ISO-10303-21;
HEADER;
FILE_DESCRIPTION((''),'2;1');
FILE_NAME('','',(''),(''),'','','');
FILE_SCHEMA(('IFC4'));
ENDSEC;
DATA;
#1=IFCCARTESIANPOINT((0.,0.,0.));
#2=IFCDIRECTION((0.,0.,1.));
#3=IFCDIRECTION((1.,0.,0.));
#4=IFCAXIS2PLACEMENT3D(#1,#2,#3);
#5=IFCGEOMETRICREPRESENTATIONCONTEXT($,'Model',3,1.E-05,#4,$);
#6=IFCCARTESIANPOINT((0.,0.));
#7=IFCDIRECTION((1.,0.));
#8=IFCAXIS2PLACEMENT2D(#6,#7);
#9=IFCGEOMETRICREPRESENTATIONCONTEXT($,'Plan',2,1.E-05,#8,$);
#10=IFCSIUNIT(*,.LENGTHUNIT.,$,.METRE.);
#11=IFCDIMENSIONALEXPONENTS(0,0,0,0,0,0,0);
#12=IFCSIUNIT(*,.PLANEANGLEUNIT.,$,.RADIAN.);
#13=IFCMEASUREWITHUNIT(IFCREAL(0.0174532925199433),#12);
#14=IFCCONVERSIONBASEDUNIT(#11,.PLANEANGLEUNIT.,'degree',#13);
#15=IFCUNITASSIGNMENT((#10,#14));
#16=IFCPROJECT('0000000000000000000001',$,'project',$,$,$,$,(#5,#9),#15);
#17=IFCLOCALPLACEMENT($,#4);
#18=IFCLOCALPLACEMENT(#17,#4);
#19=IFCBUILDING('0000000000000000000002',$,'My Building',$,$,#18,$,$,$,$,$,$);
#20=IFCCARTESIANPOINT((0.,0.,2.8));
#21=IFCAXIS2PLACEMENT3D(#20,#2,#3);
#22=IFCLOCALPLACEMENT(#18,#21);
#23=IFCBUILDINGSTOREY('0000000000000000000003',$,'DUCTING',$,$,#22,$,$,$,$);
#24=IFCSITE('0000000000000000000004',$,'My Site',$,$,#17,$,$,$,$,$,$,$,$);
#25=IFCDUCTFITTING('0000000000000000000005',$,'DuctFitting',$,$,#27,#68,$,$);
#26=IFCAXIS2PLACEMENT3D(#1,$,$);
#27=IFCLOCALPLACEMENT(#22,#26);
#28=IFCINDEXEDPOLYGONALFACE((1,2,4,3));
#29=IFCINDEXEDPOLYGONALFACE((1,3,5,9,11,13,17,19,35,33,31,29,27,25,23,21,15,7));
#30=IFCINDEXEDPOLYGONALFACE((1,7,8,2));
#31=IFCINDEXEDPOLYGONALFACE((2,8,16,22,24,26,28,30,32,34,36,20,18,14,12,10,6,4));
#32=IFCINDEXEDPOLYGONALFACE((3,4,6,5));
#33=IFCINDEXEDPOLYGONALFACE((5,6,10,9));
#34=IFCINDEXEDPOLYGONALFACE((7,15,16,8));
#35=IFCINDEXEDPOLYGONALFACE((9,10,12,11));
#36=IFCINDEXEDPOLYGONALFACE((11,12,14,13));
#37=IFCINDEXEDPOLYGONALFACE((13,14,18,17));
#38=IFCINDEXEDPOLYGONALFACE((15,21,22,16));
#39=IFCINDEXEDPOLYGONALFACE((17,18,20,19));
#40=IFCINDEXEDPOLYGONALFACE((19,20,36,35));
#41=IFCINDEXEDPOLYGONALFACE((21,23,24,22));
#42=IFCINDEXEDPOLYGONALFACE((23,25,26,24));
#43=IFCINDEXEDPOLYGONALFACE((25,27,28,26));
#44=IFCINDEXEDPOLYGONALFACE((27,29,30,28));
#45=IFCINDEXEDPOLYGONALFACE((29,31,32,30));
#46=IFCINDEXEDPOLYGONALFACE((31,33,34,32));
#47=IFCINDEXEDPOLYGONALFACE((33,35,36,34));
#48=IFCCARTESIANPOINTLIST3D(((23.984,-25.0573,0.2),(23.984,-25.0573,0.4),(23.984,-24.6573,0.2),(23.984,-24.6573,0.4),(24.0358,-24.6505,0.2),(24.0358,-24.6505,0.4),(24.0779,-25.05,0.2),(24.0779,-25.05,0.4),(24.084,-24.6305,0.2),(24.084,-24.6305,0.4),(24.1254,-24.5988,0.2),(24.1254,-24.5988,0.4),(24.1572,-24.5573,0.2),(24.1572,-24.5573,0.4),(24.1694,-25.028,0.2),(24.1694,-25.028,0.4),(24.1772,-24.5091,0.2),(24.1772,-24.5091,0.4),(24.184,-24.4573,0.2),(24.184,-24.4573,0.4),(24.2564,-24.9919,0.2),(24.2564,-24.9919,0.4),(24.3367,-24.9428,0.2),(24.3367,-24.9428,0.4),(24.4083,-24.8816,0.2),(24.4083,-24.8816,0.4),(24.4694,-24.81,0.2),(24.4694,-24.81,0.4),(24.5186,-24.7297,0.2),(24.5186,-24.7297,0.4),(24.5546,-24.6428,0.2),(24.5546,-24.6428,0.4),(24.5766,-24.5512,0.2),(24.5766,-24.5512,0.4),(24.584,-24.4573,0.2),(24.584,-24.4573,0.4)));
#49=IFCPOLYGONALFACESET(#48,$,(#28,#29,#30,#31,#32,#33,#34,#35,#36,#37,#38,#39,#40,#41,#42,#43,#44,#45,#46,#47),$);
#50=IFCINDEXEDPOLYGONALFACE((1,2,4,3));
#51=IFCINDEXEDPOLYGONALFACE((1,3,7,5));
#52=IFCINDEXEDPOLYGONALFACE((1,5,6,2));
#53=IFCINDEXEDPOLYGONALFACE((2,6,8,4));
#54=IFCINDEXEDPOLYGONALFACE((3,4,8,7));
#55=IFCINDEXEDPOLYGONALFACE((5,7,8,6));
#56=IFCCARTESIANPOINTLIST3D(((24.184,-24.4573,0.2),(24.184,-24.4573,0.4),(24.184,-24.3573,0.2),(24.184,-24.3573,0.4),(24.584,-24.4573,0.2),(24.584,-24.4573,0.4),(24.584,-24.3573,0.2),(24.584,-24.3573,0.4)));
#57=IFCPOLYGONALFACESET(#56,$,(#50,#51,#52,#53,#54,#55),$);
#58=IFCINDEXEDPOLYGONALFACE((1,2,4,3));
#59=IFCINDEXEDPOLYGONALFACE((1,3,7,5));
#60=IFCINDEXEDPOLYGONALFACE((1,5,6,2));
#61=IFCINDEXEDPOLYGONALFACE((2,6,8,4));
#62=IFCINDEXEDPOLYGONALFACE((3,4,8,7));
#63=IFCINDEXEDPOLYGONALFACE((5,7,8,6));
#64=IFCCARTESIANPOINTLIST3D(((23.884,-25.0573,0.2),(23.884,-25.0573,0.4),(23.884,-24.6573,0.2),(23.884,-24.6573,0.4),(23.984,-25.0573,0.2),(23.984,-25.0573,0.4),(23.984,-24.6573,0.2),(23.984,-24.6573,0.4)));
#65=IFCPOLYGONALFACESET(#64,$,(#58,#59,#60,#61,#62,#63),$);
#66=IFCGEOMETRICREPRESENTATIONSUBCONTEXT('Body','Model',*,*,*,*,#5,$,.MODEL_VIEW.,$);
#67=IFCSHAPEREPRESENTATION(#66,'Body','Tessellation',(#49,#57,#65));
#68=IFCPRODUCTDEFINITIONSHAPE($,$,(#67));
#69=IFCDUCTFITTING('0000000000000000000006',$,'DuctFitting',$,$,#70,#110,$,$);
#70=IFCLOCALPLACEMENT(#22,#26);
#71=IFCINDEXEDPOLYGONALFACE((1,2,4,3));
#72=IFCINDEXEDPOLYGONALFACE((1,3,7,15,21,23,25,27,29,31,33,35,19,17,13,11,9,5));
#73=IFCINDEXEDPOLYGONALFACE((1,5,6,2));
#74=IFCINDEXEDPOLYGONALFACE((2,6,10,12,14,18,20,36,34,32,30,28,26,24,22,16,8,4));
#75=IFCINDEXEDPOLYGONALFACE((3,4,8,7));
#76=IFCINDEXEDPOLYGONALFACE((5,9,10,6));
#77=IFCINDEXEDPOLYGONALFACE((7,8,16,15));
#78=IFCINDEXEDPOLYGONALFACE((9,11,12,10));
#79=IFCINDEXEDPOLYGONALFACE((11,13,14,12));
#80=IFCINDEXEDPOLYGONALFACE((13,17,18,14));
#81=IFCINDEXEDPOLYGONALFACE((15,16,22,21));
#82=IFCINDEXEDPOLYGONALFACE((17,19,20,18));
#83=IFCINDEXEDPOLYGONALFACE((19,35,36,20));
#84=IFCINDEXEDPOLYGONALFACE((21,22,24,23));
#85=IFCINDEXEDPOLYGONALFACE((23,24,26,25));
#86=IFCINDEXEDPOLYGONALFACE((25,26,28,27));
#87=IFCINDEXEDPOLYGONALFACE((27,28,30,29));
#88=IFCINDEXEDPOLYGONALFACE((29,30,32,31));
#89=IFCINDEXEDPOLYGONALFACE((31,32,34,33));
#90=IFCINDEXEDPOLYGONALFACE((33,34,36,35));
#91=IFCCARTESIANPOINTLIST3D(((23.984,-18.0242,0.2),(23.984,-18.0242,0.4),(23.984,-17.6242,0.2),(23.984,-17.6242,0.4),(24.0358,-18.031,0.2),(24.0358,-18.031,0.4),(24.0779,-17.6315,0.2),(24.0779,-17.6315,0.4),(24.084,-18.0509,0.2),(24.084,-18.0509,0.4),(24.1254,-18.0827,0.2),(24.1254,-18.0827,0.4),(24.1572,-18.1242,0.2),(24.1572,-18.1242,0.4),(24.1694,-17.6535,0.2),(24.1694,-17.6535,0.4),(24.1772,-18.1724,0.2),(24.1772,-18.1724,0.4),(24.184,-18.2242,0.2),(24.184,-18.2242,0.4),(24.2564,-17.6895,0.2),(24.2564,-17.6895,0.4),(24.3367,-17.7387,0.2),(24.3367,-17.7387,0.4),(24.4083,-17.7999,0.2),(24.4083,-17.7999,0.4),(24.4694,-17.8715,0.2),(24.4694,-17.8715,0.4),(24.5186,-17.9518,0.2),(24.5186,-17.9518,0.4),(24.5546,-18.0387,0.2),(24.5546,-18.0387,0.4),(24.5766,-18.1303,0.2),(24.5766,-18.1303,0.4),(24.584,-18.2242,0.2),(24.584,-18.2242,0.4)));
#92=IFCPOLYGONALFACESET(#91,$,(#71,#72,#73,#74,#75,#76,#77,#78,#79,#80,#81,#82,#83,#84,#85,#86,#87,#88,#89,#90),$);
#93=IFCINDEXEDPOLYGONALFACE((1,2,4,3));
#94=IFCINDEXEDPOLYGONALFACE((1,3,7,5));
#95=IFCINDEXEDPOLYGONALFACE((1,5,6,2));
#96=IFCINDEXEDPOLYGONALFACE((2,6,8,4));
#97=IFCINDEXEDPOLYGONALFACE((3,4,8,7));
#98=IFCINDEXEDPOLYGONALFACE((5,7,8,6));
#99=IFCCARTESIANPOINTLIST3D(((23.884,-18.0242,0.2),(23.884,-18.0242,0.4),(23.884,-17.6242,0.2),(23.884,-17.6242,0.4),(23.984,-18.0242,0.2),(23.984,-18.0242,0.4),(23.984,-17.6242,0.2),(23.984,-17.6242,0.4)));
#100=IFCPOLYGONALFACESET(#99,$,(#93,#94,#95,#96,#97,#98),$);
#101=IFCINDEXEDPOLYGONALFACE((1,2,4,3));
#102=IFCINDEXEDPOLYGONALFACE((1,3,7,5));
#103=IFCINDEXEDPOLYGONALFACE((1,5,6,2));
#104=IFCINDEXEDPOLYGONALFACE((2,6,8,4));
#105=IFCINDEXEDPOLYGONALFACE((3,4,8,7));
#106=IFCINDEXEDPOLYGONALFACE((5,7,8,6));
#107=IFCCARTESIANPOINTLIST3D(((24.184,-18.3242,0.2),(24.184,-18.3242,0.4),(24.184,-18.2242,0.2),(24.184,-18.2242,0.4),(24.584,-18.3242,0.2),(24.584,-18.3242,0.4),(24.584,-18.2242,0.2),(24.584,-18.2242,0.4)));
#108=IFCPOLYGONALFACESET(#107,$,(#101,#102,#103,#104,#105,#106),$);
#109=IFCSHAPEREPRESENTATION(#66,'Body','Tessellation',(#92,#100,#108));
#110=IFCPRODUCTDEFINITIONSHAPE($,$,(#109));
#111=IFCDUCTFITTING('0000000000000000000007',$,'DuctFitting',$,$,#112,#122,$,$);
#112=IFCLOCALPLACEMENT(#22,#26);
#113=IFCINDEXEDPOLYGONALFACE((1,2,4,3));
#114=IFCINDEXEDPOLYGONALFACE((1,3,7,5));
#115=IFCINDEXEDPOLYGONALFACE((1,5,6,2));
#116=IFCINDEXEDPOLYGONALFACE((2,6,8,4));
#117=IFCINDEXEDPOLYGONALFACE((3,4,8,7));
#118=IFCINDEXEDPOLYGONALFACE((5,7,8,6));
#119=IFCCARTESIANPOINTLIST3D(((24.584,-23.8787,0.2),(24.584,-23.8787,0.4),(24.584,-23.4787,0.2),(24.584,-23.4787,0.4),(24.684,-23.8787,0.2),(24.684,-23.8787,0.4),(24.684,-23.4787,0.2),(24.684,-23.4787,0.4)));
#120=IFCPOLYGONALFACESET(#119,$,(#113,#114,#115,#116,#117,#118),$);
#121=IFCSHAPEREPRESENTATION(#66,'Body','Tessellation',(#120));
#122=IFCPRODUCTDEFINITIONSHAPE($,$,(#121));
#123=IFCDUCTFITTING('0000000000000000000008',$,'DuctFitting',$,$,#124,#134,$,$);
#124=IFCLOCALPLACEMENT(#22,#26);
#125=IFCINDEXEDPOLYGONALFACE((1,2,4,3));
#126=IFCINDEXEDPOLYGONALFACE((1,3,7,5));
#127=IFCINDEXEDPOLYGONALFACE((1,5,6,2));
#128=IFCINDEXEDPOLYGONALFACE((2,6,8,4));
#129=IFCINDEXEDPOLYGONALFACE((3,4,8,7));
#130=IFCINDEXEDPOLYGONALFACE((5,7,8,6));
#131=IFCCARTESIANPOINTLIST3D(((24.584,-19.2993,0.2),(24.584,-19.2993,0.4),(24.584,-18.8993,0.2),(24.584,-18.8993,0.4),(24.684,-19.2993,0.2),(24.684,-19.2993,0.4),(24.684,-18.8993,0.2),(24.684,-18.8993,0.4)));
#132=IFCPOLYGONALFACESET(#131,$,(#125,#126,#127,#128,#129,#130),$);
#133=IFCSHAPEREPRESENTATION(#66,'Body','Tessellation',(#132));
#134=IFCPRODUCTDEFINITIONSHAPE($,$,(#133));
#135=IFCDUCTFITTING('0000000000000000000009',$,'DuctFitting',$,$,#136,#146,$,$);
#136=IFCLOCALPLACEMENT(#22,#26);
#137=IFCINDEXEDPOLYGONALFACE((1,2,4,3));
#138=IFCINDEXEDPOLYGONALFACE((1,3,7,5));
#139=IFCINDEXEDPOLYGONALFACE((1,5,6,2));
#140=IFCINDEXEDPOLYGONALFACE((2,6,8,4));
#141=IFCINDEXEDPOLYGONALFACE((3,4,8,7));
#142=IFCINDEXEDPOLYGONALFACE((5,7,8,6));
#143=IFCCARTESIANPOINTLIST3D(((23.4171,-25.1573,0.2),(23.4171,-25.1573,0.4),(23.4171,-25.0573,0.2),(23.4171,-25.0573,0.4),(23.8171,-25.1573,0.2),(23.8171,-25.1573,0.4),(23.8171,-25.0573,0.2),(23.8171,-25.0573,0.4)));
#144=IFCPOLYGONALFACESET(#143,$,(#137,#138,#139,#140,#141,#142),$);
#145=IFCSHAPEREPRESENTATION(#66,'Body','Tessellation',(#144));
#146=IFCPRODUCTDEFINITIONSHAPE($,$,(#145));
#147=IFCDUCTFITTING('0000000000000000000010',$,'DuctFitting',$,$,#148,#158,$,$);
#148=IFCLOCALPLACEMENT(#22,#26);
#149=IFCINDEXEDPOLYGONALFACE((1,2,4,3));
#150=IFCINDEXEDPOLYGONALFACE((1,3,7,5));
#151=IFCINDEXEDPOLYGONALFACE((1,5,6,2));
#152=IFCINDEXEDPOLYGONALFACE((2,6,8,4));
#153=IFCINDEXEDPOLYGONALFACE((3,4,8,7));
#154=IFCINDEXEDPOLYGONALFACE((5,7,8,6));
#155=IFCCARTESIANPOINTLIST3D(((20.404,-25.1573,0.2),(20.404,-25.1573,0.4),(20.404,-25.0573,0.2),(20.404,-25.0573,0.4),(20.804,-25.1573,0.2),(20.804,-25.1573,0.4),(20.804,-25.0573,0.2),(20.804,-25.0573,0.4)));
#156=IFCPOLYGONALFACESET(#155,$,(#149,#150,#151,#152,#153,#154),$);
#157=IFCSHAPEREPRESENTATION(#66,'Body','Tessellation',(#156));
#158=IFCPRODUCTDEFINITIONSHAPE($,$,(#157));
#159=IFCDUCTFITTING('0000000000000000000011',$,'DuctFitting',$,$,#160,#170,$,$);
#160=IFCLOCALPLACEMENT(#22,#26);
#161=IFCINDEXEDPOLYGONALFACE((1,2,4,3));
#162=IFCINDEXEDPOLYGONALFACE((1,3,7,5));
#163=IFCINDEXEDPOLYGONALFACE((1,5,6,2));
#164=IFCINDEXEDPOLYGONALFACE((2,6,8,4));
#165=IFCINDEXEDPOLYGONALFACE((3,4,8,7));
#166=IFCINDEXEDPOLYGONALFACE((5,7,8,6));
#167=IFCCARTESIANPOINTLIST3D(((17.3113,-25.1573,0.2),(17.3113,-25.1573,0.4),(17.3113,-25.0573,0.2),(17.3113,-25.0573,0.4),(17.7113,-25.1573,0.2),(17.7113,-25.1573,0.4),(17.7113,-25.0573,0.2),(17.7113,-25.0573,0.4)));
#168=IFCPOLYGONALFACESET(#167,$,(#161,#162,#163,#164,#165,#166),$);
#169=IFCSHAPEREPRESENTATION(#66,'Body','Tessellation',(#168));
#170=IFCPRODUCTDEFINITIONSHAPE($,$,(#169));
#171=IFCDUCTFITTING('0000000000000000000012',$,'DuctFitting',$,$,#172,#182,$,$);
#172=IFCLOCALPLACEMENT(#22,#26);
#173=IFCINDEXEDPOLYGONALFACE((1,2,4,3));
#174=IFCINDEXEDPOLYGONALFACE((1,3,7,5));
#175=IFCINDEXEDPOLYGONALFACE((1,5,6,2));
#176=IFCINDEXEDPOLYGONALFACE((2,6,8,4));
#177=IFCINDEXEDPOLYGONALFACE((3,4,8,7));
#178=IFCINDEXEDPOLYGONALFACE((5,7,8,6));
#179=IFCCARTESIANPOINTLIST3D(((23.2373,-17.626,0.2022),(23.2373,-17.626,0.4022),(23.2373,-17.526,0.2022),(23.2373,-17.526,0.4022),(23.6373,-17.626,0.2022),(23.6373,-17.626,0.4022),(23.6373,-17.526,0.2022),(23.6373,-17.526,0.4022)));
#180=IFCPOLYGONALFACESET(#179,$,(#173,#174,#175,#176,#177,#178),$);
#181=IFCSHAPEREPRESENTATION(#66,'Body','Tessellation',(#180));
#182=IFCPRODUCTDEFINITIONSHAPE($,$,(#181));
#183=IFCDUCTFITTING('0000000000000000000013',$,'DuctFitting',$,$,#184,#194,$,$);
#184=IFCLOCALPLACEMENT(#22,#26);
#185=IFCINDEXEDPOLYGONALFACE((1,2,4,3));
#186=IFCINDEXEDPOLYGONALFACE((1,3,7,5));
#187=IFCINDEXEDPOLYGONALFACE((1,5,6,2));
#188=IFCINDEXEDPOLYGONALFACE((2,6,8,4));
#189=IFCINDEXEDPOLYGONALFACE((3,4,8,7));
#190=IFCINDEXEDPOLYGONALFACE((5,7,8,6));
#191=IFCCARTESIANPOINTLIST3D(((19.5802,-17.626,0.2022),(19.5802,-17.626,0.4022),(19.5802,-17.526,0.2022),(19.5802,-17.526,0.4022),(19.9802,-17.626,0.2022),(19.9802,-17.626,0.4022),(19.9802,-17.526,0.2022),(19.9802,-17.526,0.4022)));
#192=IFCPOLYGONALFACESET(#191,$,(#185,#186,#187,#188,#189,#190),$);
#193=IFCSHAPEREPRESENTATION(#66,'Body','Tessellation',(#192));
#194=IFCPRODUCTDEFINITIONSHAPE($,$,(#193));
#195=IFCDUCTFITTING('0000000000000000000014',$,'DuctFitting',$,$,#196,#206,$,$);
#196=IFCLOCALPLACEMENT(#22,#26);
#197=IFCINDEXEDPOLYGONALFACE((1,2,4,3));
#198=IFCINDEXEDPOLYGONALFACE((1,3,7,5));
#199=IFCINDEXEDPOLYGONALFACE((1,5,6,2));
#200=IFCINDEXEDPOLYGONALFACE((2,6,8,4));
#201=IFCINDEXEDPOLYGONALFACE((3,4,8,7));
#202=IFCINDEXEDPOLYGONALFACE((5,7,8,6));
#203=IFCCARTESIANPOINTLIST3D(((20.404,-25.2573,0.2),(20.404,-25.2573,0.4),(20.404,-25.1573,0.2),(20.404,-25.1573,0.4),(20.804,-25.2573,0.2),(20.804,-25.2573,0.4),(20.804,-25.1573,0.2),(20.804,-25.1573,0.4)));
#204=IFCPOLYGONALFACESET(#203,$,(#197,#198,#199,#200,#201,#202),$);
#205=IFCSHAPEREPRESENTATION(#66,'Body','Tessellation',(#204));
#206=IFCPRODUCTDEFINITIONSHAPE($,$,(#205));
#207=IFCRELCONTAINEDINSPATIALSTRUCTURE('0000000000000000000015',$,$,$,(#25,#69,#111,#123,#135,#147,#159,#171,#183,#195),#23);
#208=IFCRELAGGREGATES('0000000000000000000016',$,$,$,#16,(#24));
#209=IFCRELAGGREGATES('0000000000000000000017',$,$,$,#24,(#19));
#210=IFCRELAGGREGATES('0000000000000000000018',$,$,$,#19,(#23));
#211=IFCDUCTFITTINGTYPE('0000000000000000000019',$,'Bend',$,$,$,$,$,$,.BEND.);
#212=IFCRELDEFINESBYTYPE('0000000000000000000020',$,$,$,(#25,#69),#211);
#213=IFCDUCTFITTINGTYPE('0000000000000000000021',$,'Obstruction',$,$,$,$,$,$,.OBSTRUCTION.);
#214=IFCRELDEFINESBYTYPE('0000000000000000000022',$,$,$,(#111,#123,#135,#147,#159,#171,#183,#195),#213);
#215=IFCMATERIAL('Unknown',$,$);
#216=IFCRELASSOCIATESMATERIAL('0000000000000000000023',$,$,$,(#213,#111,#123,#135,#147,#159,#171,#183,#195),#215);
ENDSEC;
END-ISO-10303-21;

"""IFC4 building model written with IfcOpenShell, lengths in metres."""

from ifc_helpers import new_model, entity, si_unit, converted_unit, frame, origin_with_axes, origin_2d_with_axis, place, context, subcontext, project, spatial, line, arc, indexed_curve, rectangle, outline, extrude, source, transform, mapped, material, material_profile, profile_set, profile_usage, type_object, type_shapes, element, save


model = new_model("IFC4")

# Units and contexts
model_context = context("Model", 3, precision=1e-05, world=origin_with_axes())
plan_context = context("Plan", 2, precision=1e-05, world=origin_2d_with_axis())
body_context = subcontext(model_context, "Body", "Model", "MODEL_VIEW")
ifc_project = project(units=[si_unit("LENGTHUNIT", "METRE"), converted_unit("PLANEANGLEUNIT", "degree", entity("IfcReal", 0.0174532925199433), si_unit("PLANEANGLEUNIT", "RADIAN"), dimensions=[0, 0, 0, 0, 0, 0, 0])], contexts=[model_context, plan_context])

# Site, building, storey
site_placement = place(None, origin_with_axes())
site = spatial("IfcSite", under=ifc_project, at=site_placement, Name="My Site")
building_placement = place(site_placement, origin_with_axes())
building = spatial("IfcBuilding", under=site, at=building_placement, Name="My Building")
storey_placement = place(building_placement, frame((0.0, 0.0, 2.8), z_axis=(0.0, 0.0, 1.0), x_axis=(1.0, 0.0, 0.0)))
storey = spatial("IfcBuildingStorey", under=building, at=storey_placement, Name="DUCTING")

# Shared definitions
ifc_material = material(Name="Unknown")

# Duct fittings
duct_fitting_type_1 = type_object("IfcDuctFittingType", Name="Bend", PredefinedType="BEND")
shared_shape = source(origin_with_axes(), body_context, "Body", "SweptSolid", [
    extrude(outline(indexed_curve([(-0.2, 0.0), (-0.2586, 0.1414), (-0.4, 0.2), (-0.4, 0.6), (0.0243, 0.4243), (0.2, 0.0)], segments=[arc(1, 2, 3), line(3, 4), arc(4, 5, 6), line(6, 1)])), frame((0.0, -0.1, 0.1), z_axis=(0.0, -1.0, 0.0), x_axis=(1.0, 0.0, 0.0)), (0.0, 0.0, -1.0), 0.2),
    extrude(rectangle(XDim=0.4, YDim=0.2), origin_with_axes(), (0.0, 0.0, 1.0), 0.1),
    extrude(rectangle(XDim=0.4, YDim=0.2), frame((-0.4, 0.0, 0.5), z_axis=(-1.0, 0.0, 0.0), x_axis=(0.0, 0.0, -1.0)), (0.0, 0.0, 1.0), 0.1),
])
type_shapes(duct_fitting_type_1, [shared_shape])
for number, where, z_axis, x_axis, name in (
    (1, (24.384, -24.3573, 0.3), (0.0, -1.0, 0.000006), (1.0, 0.0, 0.0), "DuctFitting"),
    (2, (23.884, -17.8242, 0.3), (1.0, 0.0, 0.0), (0.0, 1.0, 0.0), "DuctFitting"),
):
    element("IfcDuctFitting", number, at=place(storey_placement, frame(where, z_axis=z_axis, x_axis=x_axis)), inside=storey, type_object=duct_fitting_type_1, Name=name, context=body_context, shape_type="MappedRepresentation", body=[
        mapped(shared_shape, transform((0.0, 0.0, 0.0), x_axis=(1.0, 0.0, 0.0), y_axis=(0.0, 1.0, 0.0), z_axis=(0.0, 0.0, 1.0), scale=1.0)),
    ])
ifc_material_profile_1 = material_profile(ifc_material, rectangle(XDim=0.4, YDim=0.2))
ifc_profile_set_1 = profile_set([ifc_material_profile_1])
ifc_profile_usage_1 = profile_usage(ifc_profile_set_1, cardinal=5)
duct_fitting_type_2 = type_object("IfcDuctFittingType", Name="Obstruction", PredefinedType="OBSTRUCTION", material=ifc_profile_set_1)
duct_fitting_1_placement = place(storey_placement, frame((24.584, -23.6787, 0.3), z_axis=(1.0, 0.0, 0.0), x_axis=(0.0, 1.0, 0.0)))
element("IfcDuctFitting", 3, at=duct_fitting_1_placement, inside=storey, type_object=duct_fitting_type_2, material=ifc_profile_usage_1, Name="DuctFitting", context=body_context, shape_type="SweptSolid", body=[
    extrude(rectangle(XDim=0.4, YDim=0.2), origin_with_axes(), (0.0, 0.0, 1.0), 0.1),
])
ifc_profile_usage_2 = profile_usage(ifc_profile_set_1, cardinal=5)
duct_fitting_2_placement = place(storey_placement, frame((24.584, -19.0993, 0.3), z_axis=(1.0, 0.0, 0.0), x_axis=(0.0, 1.0, 0.0)))
element("IfcDuctFitting", 4, at=duct_fitting_2_placement, inside=storey, type_object=duct_fitting_type_2, material=ifc_profile_usage_2, Name="DuctFitting", context=body_context, shape_type="SweptSolid", body=[
    extrude(rectangle(XDim=0.4, YDim=0.2), origin_with_axes(), (0.0, 0.0, 1.0), 0.1),
])
ifc_profile_usage_3 = profile_usage(ifc_profile_set_1, cardinal=5)
duct_fitting_3_placement = place(storey_placement, frame((23.6171, -25.0573, 0.3), z_axis=(0.0, -1.0, 0.0), x_axis=(1.0, 0.0, 0.0)))
element("IfcDuctFitting", 5, at=duct_fitting_3_placement, inside=storey, type_object=duct_fitting_type_2, material=ifc_profile_usage_3, Name="DuctFitting", context=body_context, shape_type="SweptSolid", body=[
    extrude(rectangle(XDim=0.4, YDim=0.2), origin_with_axes(), (0.0, 0.0, 1.0), 0.1),
])
ifc_profile_usage_4 = profile_usage(ifc_profile_set_1, cardinal=5)
duct_fitting_4_placement = place(storey_placement, frame((20.604, -25.0573, 0.3), z_axis=(0.0, -1.0, 0.0), x_axis=(1.0, 0.0, 0.0)))
element("IfcDuctFitting", 6, at=duct_fitting_4_placement, inside=storey, type_object=duct_fitting_type_2, material=ifc_profile_usage_4, Name="DuctFitting", context=body_context, shape_type="SweptSolid", body=[
    extrude(rectangle(XDim=0.4, YDim=0.2), origin_with_axes(), (0.0, 0.0, 1.0), 0.1),
])
ifc_profile_usage_5 = profile_usage(ifc_profile_set_1, cardinal=5)
duct_fitting_5_placement = place(storey_placement, frame((17.5113, -25.0573, 0.3), z_axis=(0.0, -1.0, 0.0), x_axis=(1.0, 0.0, 0.0)))
element("IfcDuctFitting", 7, at=duct_fitting_5_placement, inside=storey, type_object=duct_fitting_type_2, material=ifc_profile_usage_5, Name="DuctFitting", context=body_context, shape_type="SweptSolid", body=[
    extrude(rectangle(XDim=0.4, YDim=0.2), origin_with_axes(), (0.0, 0.0, 1.0), 0.1),
])
ifc_profile_usage_6 = profile_usage(ifc_profile_set_1, cardinal=5)
duct_fitting_6_placement = place(storey_placement, frame((23.4373, -17.526, 0.3022), z_axis=(0.0, -1.0, 0.000003), x_axis=(1.0, 0.0, 0.0)))
element("IfcDuctFitting", 8, at=duct_fitting_6_placement, inside=storey, type_object=duct_fitting_type_2, material=ifc_profile_usage_6, Name="DuctFitting", context=body_context, shape_type="SweptSolid", body=[
    extrude(rectangle(XDim=0.4, YDim=0.2), origin_with_axes(), (0.0, 0.0, 1.0), 0.1),
])
ifc_profile_usage_7 = profile_usage(ifc_profile_set_1, cardinal=5)
duct_fitting_7_placement = place(storey_placement, frame((19.7802, -17.526, 0.3022), z_axis=(0.0, -1.0, 0.000003), x_axis=(1.0, 0.0, 0.0)))
element("IfcDuctFitting", 9, at=duct_fitting_7_placement, inside=storey, type_object=duct_fitting_type_2, material=ifc_profile_usage_7, Name="DuctFitting", context=body_context, shape_type="SweptSolid", body=[
    extrude(rectangle(XDim=0.4, YDim=0.2), origin_with_axes(), (0.0, 0.0, 1.0), 0.1),
])
ifc_profile_usage_8 = profile_usage(ifc_profile_set_1, cardinal=5)
duct_fitting_8_placement = place(storey_placement, frame((20.604, -25.1573, 0.3), z_axis=(0.0, -1.0, 0.0), x_axis=(1.0, 0.0, 0.0)))
element("IfcDuctFitting", 10, at=duct_fitting_8_placement, inside=storey, type_object=duct_fitting_type_2, material=ifc_profile_usage_8, Name="DuctFitting", context=body_context, shape_type="SweptSolid", body=[
    extrude(rectangle(XDim=0.4, YDim=0.2), origin_with_axes(), (0.0, 0.0, 1.0), 0.1),
])

save(model, "model.ifc")
